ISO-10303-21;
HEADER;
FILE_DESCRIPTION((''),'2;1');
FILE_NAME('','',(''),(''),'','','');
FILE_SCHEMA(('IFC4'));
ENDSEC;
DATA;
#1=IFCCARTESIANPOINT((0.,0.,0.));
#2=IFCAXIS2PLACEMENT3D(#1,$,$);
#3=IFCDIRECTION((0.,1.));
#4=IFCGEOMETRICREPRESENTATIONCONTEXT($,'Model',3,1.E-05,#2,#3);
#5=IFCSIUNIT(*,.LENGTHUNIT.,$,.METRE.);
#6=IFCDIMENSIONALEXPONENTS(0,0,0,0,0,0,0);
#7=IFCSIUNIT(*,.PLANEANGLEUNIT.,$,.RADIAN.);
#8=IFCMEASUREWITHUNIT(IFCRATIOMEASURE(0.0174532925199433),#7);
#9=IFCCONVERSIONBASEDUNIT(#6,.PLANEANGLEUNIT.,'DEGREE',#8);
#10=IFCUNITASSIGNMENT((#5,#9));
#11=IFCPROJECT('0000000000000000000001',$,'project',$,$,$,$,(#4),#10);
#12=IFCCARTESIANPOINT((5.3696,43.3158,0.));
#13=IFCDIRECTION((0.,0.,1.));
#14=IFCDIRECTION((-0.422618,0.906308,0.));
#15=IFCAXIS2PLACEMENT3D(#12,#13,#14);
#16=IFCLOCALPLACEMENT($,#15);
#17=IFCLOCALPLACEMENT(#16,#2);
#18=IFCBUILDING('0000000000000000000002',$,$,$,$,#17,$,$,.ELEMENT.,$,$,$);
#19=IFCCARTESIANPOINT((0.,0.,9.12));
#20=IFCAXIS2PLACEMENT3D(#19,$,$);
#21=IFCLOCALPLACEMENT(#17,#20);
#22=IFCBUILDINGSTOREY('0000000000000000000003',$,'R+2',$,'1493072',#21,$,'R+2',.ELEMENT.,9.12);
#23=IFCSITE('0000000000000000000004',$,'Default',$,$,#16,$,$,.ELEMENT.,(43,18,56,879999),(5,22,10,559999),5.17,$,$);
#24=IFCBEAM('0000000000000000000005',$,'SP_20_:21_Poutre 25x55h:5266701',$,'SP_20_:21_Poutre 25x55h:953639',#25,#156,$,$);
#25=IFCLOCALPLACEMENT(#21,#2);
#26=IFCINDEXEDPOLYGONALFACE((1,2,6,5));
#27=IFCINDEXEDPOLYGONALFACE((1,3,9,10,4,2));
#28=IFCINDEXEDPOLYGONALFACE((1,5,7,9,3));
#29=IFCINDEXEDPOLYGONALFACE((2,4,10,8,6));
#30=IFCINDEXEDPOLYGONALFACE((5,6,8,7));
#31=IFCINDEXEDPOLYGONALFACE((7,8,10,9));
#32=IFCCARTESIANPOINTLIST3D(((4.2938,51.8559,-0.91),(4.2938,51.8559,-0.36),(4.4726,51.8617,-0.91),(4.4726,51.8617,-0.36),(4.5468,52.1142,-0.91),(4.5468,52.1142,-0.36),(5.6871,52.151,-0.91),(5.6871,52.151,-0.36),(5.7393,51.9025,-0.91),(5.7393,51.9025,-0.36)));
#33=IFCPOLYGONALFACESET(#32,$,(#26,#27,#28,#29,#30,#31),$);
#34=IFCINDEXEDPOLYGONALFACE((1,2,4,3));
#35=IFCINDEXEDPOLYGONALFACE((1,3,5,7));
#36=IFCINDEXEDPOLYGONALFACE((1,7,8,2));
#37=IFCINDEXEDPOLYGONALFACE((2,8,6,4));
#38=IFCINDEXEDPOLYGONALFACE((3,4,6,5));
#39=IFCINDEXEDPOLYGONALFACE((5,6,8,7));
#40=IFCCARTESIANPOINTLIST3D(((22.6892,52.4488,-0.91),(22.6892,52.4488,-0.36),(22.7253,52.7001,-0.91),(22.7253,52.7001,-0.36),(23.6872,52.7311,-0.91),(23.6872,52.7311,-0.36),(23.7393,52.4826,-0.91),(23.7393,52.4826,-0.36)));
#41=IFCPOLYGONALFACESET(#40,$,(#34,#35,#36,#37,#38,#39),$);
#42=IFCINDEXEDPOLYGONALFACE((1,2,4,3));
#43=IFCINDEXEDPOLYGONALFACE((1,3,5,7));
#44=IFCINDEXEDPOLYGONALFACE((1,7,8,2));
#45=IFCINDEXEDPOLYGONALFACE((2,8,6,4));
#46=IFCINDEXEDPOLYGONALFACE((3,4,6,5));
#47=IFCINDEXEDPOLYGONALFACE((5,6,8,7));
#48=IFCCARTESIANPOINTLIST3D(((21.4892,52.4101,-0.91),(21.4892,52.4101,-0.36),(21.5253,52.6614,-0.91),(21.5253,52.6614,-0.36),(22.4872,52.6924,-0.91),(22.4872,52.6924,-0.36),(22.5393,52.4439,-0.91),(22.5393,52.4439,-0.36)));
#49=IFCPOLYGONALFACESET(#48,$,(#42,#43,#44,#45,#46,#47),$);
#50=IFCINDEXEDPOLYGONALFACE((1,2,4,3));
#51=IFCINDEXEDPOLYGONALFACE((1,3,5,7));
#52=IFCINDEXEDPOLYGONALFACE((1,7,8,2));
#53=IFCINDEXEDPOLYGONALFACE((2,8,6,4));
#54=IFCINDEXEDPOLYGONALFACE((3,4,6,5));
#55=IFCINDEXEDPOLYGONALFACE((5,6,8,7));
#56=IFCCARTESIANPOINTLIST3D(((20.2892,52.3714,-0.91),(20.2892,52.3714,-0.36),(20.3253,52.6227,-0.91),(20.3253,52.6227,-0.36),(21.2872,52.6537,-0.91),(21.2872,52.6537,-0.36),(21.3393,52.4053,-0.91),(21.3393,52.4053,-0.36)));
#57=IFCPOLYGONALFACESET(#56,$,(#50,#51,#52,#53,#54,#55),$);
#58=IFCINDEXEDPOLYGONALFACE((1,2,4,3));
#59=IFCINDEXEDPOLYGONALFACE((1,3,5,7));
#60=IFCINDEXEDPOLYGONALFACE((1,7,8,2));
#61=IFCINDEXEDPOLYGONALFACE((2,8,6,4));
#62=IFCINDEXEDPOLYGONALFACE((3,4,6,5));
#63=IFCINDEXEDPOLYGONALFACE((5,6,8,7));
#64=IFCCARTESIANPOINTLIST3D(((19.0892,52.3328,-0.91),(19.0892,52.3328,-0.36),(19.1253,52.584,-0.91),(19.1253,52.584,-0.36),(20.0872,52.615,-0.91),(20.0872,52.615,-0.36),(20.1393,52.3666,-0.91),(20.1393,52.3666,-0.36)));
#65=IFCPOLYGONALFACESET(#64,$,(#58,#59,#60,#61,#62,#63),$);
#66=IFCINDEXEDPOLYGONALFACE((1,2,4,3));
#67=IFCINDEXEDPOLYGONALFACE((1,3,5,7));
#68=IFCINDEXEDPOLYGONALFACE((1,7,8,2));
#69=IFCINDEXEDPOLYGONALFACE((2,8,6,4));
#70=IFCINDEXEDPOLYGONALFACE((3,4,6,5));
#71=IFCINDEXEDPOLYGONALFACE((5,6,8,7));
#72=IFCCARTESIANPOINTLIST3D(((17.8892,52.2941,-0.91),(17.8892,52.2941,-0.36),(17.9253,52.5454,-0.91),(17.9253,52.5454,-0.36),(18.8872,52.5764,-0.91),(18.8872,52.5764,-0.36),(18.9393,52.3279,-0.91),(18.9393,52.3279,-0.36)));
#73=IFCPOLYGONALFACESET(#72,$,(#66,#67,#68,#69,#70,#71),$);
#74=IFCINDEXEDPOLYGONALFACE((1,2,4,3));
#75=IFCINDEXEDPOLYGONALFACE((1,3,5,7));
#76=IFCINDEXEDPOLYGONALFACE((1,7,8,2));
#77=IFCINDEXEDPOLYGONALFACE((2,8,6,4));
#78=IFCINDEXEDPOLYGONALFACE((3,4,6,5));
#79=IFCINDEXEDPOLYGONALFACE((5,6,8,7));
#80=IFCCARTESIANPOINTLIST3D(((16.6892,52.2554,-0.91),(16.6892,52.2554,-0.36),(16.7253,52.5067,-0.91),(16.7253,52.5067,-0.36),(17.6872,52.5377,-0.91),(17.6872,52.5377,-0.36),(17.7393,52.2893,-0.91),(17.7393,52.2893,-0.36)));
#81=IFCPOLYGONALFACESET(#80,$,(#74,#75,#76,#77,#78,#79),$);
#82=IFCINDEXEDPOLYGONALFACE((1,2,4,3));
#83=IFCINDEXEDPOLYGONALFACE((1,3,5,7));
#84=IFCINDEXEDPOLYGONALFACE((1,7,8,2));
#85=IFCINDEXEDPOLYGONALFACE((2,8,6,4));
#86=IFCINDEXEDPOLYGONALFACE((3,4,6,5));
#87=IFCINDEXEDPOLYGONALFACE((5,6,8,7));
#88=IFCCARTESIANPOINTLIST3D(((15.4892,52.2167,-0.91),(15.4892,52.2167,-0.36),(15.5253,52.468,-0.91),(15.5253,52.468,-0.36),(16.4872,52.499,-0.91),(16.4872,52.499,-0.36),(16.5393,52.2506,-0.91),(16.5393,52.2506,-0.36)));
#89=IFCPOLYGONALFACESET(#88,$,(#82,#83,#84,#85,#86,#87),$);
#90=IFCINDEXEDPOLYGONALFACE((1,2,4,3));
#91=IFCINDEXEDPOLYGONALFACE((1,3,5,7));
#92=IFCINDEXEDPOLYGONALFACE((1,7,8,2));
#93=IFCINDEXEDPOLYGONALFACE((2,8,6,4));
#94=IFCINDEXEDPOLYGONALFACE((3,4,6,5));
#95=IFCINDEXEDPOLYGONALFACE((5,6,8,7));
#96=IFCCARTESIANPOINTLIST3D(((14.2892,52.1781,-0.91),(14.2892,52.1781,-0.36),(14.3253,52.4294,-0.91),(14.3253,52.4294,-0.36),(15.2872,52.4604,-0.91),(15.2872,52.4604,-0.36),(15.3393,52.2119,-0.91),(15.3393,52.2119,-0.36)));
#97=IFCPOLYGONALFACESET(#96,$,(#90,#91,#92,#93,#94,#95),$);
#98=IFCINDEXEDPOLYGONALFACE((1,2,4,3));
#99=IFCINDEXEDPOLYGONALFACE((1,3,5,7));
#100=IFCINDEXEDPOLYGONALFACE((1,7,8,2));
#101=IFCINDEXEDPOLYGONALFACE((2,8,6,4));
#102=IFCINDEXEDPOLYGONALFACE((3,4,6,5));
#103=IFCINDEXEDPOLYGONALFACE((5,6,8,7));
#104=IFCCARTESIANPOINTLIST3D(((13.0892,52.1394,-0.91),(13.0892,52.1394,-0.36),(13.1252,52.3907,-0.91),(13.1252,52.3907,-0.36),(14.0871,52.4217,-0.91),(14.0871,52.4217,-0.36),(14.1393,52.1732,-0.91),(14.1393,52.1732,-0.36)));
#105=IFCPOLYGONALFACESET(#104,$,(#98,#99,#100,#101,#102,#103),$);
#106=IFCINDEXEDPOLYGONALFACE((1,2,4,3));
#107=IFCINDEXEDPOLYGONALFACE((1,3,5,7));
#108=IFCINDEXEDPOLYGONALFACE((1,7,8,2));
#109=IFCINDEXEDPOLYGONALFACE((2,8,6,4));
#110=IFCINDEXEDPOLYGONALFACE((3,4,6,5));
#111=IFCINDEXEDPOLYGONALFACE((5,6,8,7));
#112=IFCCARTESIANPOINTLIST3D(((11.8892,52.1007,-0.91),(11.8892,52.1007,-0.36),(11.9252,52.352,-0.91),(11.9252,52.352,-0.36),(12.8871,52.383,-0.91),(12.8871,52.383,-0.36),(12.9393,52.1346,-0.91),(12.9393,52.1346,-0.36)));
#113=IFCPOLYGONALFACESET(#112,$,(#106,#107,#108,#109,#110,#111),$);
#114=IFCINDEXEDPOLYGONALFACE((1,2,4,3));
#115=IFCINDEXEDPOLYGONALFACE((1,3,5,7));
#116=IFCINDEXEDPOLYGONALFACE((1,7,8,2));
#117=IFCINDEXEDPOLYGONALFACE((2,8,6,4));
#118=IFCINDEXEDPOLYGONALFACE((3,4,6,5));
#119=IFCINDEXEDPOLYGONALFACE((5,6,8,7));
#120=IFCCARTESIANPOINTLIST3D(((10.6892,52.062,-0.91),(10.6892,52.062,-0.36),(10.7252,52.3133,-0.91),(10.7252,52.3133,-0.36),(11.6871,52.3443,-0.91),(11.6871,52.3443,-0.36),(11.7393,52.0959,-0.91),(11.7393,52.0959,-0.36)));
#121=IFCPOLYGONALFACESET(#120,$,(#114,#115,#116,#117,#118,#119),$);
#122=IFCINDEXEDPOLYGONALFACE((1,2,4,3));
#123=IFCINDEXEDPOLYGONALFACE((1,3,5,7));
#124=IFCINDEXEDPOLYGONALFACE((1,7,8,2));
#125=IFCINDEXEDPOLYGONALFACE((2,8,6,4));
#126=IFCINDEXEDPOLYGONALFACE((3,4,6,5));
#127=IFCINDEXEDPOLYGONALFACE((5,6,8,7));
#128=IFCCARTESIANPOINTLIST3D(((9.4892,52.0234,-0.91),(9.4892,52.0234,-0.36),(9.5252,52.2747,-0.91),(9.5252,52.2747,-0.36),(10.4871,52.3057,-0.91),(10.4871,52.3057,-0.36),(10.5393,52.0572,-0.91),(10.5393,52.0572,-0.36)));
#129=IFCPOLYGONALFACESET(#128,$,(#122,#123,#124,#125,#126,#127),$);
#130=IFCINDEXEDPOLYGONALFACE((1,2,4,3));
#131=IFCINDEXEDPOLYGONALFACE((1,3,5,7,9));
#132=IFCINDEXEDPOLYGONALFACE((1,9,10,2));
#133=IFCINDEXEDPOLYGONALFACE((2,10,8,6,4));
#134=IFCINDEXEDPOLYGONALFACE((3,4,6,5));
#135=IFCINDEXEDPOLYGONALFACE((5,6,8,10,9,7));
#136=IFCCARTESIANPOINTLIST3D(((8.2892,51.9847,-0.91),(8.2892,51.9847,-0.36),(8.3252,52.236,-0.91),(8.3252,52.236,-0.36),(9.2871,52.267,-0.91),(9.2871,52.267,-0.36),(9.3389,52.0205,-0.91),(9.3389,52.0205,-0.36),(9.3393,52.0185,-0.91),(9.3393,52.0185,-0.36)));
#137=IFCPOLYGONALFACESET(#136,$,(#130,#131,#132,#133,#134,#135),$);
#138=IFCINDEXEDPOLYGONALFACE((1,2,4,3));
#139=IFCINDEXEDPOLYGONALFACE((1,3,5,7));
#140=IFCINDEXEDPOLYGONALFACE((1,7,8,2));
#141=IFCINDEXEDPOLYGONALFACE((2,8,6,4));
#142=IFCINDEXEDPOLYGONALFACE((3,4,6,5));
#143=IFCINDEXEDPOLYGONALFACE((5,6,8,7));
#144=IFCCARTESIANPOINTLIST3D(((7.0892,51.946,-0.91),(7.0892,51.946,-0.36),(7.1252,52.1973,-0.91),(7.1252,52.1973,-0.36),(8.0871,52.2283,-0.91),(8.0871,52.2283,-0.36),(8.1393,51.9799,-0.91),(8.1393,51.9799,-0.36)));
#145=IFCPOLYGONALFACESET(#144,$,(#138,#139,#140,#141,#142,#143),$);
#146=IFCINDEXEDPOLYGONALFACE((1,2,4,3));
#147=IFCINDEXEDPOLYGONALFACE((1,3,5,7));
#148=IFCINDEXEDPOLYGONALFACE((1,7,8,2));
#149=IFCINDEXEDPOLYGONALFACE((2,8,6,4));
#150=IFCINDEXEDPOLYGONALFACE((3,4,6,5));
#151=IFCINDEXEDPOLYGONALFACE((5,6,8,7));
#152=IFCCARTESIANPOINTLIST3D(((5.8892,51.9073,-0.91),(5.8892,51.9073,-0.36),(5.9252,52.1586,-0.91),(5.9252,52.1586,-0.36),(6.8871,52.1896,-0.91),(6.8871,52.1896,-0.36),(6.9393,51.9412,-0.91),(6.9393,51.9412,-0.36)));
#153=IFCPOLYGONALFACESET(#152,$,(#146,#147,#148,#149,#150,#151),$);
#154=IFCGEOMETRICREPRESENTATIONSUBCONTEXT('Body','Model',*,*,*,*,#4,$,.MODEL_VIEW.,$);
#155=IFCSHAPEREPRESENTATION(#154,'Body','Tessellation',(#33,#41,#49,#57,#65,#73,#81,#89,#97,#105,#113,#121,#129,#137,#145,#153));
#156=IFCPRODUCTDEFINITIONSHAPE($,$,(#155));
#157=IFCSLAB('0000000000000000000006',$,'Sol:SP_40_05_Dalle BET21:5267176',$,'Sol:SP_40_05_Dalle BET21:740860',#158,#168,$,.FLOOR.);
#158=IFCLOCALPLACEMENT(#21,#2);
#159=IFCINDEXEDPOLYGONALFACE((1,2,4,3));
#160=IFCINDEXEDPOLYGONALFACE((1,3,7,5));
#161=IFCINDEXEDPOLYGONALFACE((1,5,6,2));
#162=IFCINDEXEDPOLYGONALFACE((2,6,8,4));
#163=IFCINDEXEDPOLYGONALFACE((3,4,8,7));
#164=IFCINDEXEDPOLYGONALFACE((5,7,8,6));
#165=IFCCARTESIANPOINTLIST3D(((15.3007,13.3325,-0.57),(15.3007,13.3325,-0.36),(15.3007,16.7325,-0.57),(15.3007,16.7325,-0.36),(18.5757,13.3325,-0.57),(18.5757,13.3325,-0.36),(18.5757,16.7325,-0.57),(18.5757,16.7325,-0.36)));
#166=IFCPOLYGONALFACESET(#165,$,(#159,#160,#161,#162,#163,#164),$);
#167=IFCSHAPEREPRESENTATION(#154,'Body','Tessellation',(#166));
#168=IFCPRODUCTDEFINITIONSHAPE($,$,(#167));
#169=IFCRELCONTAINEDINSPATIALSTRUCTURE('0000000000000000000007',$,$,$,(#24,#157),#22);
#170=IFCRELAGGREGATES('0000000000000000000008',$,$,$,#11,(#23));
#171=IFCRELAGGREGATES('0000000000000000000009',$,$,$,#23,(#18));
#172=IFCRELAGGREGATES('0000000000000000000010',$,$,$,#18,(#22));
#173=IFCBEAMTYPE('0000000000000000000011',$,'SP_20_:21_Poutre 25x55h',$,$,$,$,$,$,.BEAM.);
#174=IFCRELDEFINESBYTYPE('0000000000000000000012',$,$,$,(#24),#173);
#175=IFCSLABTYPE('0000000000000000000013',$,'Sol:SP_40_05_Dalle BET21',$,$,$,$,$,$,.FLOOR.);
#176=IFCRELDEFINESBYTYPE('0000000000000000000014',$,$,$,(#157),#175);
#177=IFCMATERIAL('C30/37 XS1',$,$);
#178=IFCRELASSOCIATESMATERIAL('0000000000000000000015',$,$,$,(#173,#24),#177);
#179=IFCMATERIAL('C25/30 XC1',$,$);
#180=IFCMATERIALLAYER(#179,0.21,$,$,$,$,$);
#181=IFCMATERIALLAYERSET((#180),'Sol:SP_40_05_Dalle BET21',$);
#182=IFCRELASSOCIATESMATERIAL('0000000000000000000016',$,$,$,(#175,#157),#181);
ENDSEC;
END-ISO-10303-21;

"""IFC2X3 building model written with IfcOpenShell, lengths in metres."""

from ifc_helpers import new_model, entity, si_unit, converted_unit, direction, frame, frame_2d, origin, place, context, subcontext, project, spatial, polyline, rectangle, outline, extrude, source, transform, mapped, material, layer, layer_set, layer_usage, type_object, type_shapes, element, save


model = new_model("IFC2X3")

# Units and contexts
model_context = context("Model", 3, precision=1e-05, world=origin(), true_north=direction((0.0, 1.0)))
body_context = subcontext(model_context, "Body", "Model", "MODEL_VIEW")
ifc_project = project(units=[si_unit("LENGTHUNIT", "METRE"), converted_unit("PLANEANGLEUNIT", "DEGREE", entity("IfcRatioMeasure", 0.0174532925199433), si_unit("PLANEANGLEUNIT", "RADIAN"), dimensions=[0, 0, 0, 0, 0, 0, 0])], contexts=[model_context])

# Site, building, storey
site_placement = place(None, frame((5.3696, 43.3158, 0.0), z_axis=(0.0, 0.0, 1.0), x_axis=(-0.422618, 0.906308, 0.0)))
site = spatial("IfcSite", under=ifc_project, at=site_placement, Name="Default", CompositionType="ELEMENT", RefLatitude=(43, 18, 56, 879999), RefLongitude=(5, 22, 10, 559999), RefElevation=5.17)
building_placement = place(site_placement, origin())
building = spatial("IfcBuilding", under=site, at=building_placement, CompositionType="ELEMENT")
storey_placement = place(building_placement, frame((0.0, 0.0, 9.12)))
storey = spatial("IfcBuildingStorey", under=building, at=storey_placement, Name="R+2", ObjectType="1493072", LongName="R+2", CompositionType="ELEMENT", Elevation=9.12)

# Shared definitions
ifc_material_1 = material(Name="C30/37 XS1")

# Beam
beam_type_1 = type_object("IfcBeamType", Name="SP_20_:21_Poutre 25x55h", PredefinedType="BEAM", material=ifc_material_1)
shared_shape_1 = source(origin(), body_context, "Body", "SweptSolid", [
    extrude(outline(polyline([(-0.6577, -0.1), (-0.4787, -0.1), (0.7885, -0.1), (0.7444, 0.15), (-0.3965, 0.15), (-0.6577, -0.1)])), frame((4.9479, 51.9771, 8.21), z_axis=(0.0, 0.0, 1.0), x_axis=(0.999481, 0.032212, 0.0)), (0.0, 0.0, 1.0), 0.55),
    extrude(outline(polyline([(-0.4812, -0.125), (0.4812, -0.125), (0.5253, 0.125), (-0.5253, 0.125), (-0.4812, -0.125)])), frame((23.2103, 52.5906, 8.21), z_axis=(0.0, 0.0, 1.0), x_axis=(-0.999481, -0.032212, 0.0)), (0.0, 0.0, 1.0), 0.55),
    extrude(outline(polyline([(-0.4812, -0.125), (0.4812, -0.125), (0.5253, 0.125), (-0.5253, 0.125), (-0.4812, -0.125)])), frame((22.0103, 52.552, 8.21), z_axis=(0.0, 0.0, 1.0), x_axis=(-0.999481, -0.032212, 0.0)), (0.0, 0.0, 1.0), 0.55),
    extrude(outline(polyline([(-0.4812, -0.125), (0.4812, -0.125), (0.5253, 0.125), (-0.5253, 0.125), (-0.4812, -0.125)])), frame((20.8103, 52.5133, 8.21), z_axis=(0.0, 0.0, 1.0), x_axis=(-0.999481, -0.032212, 0.0)), (0.0, 0.0, 1.0), 0.55),
    extrude(outline(polyline([(-0.4812, -0.125), (0.4812, -0.125), (0.5253, 0.125), (-0.5253, 0.125), (-0.4812, -0.125)])), frame((19.6103, 52.4746, 8.21), z_axis=(0.0, 0.0, 1.0), x_axis=(-0.999481, -0.032212, 0.0)), (0.0, 0.0, 1.0), 0.55),
    extrude(outline(polyline([(-0.4812, -0.125), (0.4812, -0.125), (0.5253, 0.125), (-0.5253, 0.125), (-0.4812, -0.125)])), frame((18.4102, 52.4359, 8.21), z_axis=(0.0, 0.0, 1.0), x_axis=(-0.999481, -0.032212, 0.0)), (0.0, 0.0, 1.0), 0.55),
    extrude(outline(polyline([(-0.4812, -0.125), (0.4812, -0.125), (0.5253, 0.125), (-0.5253, 0.125), (-0.4812, -0.125)])), frame((17.2102, 52.3973, 8.21), z_axis=(0.0, 0.0, 1.0), x_axis=(-0.999481, -0.032212, 0.0)), (0.0, 0.0, 1.0), 0.55),
    extrude(outline(polyline([(-0.4812, -0.125), (0.4812, -0.125), (0.5253, 0.125), (-0.5253, 0.125), (-0.4812, -0.125)])), frame((16.0102, 52.3586, 8.21), z_axis=(0.0, 0.0, 1.0), x_axis=(-0.999481, -0.032212, 0.0)), (0.0, 0.0, 1.0), 0.55),
    extrude(outline(polyline([(-0.4812, -0.125), (0.4812, -0.125), (0.5253, 0.125), (-0.5253, 0.125), (-0.4812, -0.125)])), frame((14.8102, 52.3199, 8.21), z_axis=(0.0, 0.0, 1.0), x_axis=(-0.999481, -0.032212, 0.0)), (0.0, 0.0, 1.0), 0.55),
    extrude(outline(polyline([(-0.4812, -0.125), (0.4812, -0.125), (0.5253, 0.125), (-0.5253, 0.125), (-0.4812, -0.125)])), frame((13.6102, 52.2812, 8.21), z_axis=(0.0, 0.0, 1.0), x_axis=(-0.999481, -0.032212, 0.0)), (0.0, 0.0, 1.0), 0.55),
    extrude(outline(polyline([(-0.4812, -0.125), (0.4812, -0.125), (0.5253, 0.125), (-0.5253, 0.125), (-0.4812, -0.125)])), frame((12.4102, 52.2426, 8.21), z_axis=(0.0, 0.0, 1.0), x_axis=(-0.999481, -0.032212, 0.0)), (0.0, 0.0, 1.0), 0.55),
    extrude(outline(polyline([(-0.4812, -0.125), (0.4812, -0.125), (0.5253, 0.125), (-0.5253, 0.125), (-0.4812, -0.125)])), frame((11.2102, 52.2039, 8.21), z_axis=(0.0, 0.0, 1.0), x_axis=(-0.999481, -0.032212, 0.0)), (0.0, 0.0, 1.0), 0.55),
    extrude(outline(polyline([(-0.4812, -0.125), (0.4812, -0.125), (0.5253, 0.125), (-0.5253, 0.125), (-0.4812, -0.125)])), frame((10.0102, 52.1652, 8.21), z_axis=(0.0, 0.0, 1.0), x_axis=(-0.999481, -0.032212, 0.0)), (0.0, 0.0, 1.0), 0.55),
    extrude(outline(polyline([(-0.3762, -0.1496), (0.5862, -0.1496), (0.6303, 0.1004), (-0.4203, 0.1004), (-0.42, 0.0984), (-0.3762, -0.1496)])), frame((8.9159, 52.1053, 8.21), z_axis=(0.0, 0.0, 1.0), x_axis=(-0.999481, -0.032212, 0.0)), (0.0, 0.0, 1.0), 0.55),
    extrude(outline(polyline([(-0.4812, -0.125), (0.4812, -0.125), (0.5253, 0.125), (-0.5253, 0.125), (-0.4812, -0.125)])), frame((7.6102, 52.0879, 8.21), z_axis=(0.0, 0.0, 1.0), x_axis=(-0.999481, -0.032212, 0.0)), (0.0, 0.0, 1.0), 0.55),
    extrude(outline(polyline([(-0.4812, -0.125), (0.4812, -0.125), (0.5253, 0.125), (-0.5253, 0.125), (-0.4812, -0.125)])), frame((6.4102, 52.0492, 8.21), z_axis=(0.0, 0.0, 1.0), x_axis=(-0.999481, -0.032212, 0.0)), (0.0, 0.0, 1.0), 0.55),
])
type_shapes(beam_type_1, [shared_shape_1])
beam_1_placement = place(storey_placement, frame((0.0, 0.0, -9.12)))
element("IfcBeam", 1, at=beam_1_placement, inside=storey, type_object=beam_type_1, material=ifc_material_1, Name="SP_20_:21_Poutre 25x55h:5266701", ObjectType="SP_20_:21_Poutre 25x55h:953639", context=body_context, shape_type="MappedRepresentation", body=[
    mapped(shared_shape_1, transform((0.0, 0.0, 0.0), scale=1.0)),
])

# Slab
ifc_material_2 = material(Name="C25/30 XC1")
ifc_layer_1 = layer(ifc_material_2, 0.21)
ifc_layer_set_1 = layer_set([ifc_layer_1], Name="Sol:SP_40_05_Dalle BET21")
ifc_layer_usage_1 = layer_usage(ifc_layer_set_1, "AXIS3", "POSITIVE", 0.0)
slab_type_1 = type_object("IfcSlabType", Name="Sol:SP_40_05_Dalle BET21", PredefinedType="FLOOR", material=ifc_layer_set_1)
slab_1_placement = place(storey_placement, origin())
element("IfcSlab", 2, at=slab_1_placement, inside=storey, type_object=slab_type_1, material=ifc_layer_usage_1, Name="Sol:SP_40_05_Dalle BET21:5267176", ObjectType="Sol:SP_40_05_Dalle BET21:740860", PredefinedType="FLOOR", context=body_context, shape_type="SweptSolid", body=[
    extrude(rectangle(XDim=3.4, YDim=3.275, at=frame_2d((0.0, 0.0), x_axis=(1.0, 0.0))), frame((16.9382, 15.0325, -0.36), z_axis=(0.0, 0.0, -1.0), x_axis=(0.0, 1.0, 0.0)), (0.0, 0.0, 1.0), 0.21),
])

save(model, "model.ifc")
